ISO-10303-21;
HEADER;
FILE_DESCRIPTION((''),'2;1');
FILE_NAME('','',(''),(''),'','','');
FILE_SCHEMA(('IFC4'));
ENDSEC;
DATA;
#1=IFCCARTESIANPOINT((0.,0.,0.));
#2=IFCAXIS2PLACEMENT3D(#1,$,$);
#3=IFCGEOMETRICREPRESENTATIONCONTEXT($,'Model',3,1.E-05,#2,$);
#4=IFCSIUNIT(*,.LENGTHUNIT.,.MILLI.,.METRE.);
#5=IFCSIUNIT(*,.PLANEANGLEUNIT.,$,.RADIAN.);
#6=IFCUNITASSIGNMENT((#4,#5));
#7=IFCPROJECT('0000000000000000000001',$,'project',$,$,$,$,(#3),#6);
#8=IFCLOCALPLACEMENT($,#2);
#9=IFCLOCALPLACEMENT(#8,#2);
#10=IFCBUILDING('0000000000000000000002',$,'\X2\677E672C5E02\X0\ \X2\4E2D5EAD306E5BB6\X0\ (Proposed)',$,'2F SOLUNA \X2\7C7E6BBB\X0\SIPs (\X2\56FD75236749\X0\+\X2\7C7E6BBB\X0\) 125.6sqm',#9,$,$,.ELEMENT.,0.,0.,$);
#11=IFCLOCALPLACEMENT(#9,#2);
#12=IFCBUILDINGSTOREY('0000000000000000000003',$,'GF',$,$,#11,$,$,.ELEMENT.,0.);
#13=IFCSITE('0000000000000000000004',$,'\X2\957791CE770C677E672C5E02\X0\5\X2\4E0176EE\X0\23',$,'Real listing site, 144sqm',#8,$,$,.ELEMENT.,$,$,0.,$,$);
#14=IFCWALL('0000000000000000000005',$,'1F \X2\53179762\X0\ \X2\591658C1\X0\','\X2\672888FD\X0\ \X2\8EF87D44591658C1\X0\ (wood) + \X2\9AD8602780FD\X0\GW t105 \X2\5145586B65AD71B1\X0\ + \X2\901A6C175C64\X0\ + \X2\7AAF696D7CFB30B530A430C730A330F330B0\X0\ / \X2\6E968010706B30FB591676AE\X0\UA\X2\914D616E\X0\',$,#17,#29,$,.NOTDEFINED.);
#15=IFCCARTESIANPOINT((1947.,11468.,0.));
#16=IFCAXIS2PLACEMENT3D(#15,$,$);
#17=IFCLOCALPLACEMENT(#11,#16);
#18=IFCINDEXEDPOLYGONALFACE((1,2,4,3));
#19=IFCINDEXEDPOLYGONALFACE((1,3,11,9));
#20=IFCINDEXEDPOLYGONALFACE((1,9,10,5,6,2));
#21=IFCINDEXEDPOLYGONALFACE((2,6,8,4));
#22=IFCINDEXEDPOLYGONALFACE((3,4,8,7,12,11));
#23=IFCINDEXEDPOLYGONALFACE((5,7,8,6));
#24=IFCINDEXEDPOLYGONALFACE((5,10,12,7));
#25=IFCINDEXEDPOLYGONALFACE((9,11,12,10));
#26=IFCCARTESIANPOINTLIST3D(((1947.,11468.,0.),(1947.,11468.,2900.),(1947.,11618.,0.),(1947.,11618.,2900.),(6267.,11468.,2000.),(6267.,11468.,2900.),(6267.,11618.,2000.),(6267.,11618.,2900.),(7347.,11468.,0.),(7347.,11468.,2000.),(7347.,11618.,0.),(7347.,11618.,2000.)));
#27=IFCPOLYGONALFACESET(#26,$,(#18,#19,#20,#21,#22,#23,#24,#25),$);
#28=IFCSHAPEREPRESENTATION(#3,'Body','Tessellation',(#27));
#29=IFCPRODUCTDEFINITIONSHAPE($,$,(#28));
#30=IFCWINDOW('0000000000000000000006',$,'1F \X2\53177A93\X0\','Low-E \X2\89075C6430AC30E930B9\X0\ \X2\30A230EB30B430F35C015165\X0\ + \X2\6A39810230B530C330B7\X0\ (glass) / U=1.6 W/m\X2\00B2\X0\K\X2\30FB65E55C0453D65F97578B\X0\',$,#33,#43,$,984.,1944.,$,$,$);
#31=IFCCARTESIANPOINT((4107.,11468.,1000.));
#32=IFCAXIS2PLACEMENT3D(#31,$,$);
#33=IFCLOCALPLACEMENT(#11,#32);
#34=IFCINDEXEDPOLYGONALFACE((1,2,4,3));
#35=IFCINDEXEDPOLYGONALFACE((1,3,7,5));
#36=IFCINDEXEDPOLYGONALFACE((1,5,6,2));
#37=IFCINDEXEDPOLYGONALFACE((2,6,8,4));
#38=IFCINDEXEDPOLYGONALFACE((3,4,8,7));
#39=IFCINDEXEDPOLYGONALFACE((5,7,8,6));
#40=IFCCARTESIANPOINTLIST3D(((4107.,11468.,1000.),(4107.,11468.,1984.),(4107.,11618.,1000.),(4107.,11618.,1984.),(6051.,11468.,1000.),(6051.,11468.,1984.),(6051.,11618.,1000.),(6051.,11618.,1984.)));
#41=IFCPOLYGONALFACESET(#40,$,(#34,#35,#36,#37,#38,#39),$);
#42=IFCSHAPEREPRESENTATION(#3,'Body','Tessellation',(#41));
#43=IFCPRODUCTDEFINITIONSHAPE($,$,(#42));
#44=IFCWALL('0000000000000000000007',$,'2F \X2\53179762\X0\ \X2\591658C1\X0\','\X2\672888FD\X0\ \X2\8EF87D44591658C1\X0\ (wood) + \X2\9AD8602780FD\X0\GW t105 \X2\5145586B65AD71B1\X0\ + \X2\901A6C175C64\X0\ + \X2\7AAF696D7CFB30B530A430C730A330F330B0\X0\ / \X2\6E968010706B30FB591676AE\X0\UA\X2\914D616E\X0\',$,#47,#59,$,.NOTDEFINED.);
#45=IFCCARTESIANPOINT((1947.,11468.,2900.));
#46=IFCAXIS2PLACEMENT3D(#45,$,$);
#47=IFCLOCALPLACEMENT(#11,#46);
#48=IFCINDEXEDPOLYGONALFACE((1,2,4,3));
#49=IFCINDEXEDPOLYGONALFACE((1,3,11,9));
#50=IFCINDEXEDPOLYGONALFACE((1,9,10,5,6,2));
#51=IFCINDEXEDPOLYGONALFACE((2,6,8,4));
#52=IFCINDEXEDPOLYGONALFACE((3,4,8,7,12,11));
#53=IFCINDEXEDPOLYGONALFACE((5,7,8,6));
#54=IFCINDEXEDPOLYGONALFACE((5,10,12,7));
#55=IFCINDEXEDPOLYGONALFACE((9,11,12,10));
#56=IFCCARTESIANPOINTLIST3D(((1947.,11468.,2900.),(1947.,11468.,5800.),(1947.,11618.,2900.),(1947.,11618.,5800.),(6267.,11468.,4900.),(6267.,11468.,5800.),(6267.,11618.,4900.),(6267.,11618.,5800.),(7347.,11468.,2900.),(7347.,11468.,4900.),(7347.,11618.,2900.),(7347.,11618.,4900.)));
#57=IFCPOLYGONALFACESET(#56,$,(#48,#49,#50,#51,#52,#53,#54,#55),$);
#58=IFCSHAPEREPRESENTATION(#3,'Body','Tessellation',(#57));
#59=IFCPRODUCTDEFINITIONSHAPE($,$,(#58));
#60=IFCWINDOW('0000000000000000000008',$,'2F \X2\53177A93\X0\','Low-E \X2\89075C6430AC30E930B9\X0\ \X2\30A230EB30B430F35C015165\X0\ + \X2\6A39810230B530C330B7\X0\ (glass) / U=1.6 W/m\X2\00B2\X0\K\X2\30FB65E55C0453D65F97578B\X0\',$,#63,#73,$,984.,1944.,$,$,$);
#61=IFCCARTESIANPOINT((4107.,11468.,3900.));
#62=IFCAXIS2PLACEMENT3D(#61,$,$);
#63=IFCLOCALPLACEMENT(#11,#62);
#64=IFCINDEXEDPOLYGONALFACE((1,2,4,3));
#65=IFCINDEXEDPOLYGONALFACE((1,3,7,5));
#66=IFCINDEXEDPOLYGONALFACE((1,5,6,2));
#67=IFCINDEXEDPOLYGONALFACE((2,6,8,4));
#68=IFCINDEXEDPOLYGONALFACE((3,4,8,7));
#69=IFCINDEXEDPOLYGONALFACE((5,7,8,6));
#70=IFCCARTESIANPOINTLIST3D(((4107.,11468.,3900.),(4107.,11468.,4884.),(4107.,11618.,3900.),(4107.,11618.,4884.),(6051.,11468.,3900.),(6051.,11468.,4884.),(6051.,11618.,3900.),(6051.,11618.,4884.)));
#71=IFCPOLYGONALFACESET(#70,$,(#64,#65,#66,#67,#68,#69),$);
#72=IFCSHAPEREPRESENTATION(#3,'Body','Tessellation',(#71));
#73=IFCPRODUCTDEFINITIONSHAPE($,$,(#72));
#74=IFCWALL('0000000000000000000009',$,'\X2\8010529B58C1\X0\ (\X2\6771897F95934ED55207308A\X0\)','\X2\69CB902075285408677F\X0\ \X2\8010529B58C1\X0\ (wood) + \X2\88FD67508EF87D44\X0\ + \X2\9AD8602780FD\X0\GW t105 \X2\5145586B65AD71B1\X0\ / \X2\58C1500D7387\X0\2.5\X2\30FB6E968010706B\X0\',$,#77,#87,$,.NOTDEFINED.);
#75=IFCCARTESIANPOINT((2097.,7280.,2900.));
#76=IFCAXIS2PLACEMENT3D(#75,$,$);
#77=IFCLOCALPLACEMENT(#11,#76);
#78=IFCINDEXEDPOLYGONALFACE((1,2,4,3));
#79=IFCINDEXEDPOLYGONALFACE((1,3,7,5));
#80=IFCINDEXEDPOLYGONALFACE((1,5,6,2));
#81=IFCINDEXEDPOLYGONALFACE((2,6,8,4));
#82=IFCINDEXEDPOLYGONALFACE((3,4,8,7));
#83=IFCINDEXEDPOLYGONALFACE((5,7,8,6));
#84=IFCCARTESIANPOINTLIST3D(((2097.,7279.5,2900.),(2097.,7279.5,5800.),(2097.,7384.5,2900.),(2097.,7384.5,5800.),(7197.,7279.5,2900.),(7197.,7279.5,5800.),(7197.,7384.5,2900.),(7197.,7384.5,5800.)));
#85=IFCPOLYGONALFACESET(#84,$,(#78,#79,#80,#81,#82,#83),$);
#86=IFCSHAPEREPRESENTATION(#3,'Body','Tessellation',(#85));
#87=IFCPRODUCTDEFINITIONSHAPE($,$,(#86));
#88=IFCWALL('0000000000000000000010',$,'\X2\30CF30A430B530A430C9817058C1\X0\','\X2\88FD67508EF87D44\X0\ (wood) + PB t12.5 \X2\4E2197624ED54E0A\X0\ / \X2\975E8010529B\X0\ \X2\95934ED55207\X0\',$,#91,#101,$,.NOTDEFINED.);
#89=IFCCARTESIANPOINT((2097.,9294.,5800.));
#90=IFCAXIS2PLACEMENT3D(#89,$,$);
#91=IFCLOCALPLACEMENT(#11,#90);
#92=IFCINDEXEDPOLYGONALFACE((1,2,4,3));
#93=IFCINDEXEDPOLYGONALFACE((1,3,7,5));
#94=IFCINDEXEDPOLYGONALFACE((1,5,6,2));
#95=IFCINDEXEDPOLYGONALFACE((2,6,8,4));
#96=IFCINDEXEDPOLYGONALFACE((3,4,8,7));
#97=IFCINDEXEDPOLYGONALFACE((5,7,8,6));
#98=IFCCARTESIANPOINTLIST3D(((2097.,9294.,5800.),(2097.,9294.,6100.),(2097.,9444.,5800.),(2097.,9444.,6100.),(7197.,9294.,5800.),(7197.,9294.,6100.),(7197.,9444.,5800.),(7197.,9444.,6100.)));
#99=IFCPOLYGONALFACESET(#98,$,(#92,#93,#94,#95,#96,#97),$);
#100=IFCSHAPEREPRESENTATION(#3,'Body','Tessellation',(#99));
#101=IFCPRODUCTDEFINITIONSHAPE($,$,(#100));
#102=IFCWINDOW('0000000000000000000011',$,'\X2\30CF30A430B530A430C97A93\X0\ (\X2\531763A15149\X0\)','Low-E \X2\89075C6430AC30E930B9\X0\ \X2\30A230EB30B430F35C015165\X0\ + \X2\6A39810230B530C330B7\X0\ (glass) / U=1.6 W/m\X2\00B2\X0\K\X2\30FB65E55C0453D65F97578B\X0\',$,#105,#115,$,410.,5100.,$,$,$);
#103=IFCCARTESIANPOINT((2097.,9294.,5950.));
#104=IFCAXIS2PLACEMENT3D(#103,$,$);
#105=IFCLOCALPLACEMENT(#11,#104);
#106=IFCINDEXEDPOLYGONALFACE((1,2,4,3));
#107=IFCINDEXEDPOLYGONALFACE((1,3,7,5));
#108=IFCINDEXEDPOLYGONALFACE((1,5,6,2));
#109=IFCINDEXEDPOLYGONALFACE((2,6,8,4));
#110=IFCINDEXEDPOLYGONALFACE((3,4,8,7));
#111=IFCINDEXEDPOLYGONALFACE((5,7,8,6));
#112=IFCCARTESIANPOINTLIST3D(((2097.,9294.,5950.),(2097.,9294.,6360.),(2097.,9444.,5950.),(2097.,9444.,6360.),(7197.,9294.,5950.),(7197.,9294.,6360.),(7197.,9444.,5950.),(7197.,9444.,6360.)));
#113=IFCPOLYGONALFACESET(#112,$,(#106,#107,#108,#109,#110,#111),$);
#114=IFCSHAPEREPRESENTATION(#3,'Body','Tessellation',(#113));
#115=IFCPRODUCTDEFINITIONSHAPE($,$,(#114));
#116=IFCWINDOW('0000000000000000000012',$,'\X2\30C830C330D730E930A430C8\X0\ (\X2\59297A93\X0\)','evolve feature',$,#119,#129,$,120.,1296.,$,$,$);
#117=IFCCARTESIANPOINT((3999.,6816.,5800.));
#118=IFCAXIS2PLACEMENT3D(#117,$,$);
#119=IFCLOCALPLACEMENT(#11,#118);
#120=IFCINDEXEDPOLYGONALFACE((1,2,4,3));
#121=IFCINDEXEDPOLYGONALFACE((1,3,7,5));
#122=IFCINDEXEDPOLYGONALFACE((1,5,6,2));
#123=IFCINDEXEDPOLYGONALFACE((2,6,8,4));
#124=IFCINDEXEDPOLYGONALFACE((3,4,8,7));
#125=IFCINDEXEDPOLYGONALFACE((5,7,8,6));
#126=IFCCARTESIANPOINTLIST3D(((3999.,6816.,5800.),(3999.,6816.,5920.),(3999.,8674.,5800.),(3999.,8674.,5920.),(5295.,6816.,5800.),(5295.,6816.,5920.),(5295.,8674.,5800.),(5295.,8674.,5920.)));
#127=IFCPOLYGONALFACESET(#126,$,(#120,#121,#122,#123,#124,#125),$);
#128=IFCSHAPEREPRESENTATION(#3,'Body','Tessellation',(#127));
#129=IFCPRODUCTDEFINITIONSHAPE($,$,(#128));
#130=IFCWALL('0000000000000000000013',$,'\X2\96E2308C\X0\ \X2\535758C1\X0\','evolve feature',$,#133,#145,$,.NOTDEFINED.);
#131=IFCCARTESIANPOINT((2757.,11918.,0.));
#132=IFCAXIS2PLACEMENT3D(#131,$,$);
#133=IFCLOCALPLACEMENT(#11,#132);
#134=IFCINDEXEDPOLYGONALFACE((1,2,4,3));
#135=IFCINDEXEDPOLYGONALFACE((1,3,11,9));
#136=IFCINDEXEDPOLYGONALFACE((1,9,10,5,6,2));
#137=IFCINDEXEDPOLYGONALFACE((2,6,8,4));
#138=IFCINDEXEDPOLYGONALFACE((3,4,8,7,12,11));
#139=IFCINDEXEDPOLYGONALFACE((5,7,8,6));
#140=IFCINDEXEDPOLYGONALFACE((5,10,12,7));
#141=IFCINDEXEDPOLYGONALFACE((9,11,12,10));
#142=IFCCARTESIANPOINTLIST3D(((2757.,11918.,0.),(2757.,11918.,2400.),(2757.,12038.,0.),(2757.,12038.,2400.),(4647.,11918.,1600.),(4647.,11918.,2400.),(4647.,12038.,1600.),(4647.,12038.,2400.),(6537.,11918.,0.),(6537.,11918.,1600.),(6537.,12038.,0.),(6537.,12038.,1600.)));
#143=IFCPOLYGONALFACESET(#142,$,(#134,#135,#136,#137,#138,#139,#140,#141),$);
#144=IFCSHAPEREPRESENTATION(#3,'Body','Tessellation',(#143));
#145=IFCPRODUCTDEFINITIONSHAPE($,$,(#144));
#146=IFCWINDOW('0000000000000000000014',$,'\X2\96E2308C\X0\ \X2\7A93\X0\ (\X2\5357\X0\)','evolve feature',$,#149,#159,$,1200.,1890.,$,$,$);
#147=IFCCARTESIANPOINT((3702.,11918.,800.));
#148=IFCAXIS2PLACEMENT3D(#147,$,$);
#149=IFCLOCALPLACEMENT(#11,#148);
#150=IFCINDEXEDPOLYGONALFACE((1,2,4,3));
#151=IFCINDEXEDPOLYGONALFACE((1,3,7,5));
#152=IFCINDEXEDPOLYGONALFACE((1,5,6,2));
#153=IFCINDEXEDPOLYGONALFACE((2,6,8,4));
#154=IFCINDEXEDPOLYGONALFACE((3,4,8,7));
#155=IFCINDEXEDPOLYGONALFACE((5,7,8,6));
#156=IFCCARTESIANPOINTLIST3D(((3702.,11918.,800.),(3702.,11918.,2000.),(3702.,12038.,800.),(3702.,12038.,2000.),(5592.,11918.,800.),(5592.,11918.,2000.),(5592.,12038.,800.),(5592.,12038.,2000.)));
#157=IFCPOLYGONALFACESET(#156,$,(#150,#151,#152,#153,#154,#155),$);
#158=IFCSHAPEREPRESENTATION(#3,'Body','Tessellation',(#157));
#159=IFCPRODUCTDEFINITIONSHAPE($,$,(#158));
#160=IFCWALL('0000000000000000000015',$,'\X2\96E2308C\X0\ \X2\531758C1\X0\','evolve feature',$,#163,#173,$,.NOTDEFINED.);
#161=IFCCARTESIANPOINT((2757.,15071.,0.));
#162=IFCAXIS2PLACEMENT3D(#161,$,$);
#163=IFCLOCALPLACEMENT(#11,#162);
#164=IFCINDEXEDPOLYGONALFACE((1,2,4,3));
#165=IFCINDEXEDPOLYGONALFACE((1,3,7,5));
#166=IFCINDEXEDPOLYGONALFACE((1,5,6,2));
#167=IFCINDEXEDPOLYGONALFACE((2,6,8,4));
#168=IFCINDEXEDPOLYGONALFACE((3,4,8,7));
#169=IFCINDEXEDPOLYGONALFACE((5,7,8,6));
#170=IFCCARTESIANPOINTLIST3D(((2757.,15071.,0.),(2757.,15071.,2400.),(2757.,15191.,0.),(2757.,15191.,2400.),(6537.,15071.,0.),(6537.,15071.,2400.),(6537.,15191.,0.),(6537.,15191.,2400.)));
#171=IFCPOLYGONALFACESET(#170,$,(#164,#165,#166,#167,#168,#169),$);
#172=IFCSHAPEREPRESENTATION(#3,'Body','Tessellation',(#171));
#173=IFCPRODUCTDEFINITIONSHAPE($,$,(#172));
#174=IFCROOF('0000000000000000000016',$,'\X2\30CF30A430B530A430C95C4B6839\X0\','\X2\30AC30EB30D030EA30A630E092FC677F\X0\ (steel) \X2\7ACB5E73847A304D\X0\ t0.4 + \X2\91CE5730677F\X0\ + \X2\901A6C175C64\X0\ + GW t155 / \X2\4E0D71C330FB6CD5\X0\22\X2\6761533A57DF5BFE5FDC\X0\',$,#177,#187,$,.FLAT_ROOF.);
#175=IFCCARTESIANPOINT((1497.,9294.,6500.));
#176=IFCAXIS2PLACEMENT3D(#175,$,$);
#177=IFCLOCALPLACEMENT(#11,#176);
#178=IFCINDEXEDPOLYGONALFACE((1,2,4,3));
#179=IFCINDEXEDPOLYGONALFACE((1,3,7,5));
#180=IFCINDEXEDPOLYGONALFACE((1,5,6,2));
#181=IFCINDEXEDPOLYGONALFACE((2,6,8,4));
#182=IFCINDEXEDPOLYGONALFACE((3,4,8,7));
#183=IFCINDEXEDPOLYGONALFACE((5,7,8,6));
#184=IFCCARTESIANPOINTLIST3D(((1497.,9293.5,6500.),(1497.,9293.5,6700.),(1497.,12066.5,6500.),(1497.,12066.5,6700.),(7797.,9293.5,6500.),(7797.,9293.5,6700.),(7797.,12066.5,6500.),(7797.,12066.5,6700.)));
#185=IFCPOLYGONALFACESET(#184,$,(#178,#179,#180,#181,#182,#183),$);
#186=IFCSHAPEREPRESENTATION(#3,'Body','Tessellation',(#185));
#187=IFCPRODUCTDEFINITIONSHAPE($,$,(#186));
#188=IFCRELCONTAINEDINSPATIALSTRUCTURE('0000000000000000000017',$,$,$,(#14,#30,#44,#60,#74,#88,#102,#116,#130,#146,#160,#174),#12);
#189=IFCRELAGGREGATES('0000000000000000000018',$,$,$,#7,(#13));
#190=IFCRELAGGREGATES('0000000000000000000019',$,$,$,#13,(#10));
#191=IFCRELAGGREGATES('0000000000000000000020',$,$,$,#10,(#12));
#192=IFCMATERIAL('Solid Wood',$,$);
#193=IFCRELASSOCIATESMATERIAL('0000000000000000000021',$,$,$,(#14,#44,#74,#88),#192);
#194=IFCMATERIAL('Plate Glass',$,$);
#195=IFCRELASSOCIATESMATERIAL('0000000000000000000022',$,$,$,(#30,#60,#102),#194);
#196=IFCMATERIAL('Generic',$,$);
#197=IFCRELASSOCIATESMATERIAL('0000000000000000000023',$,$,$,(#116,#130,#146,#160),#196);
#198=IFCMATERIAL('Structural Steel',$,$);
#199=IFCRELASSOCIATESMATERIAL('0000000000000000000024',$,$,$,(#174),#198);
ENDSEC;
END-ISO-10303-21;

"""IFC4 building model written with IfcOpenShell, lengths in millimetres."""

from ifc_helpers import new_model, si_unit, frame, frame_2d, origin, place, context, project, spatial, rectangle, extrude, material, element, fill, save


model = new_model("IFC4")

# Units and contexts
model_context = context("Model", 3, precision=1e-05, world=origin())
ifc_project = project(units=[si_unit("LENGTHUNIT", "METRE", prefix="MILLI"), si_unit("PLANEANGLEUNIT", "RADIAN")], contexts=[model_context])

# Site, building, storey
site_placement = place(None, origin())
site = spatial("IfcSite", under=ifc_project, at=site_placement, Name="長野県松本市5丁目23", ObjectType="Real listing site, 144sqm", CompositionType="ELEMENT", RefElevation=0.0)
building_placement = place(site_placement, origin())
building = spatial("IfcBuilding", under=site, at=building_placement, Name="松本市 中庭の家 (Proposed)", ObjectType="2F SOLUNA 籾殻SIPs (国産杉+籾殻) 125.6sqm", CompositionType="ELEMENT", ElevationOfRefHeight=0.0, ElevationOfTerrain=0.0)
storey_placement = place(building_placement, origin())
storey = spatial("IfcBuildingStorey", under=building, at=storey_placement, Name="GF", CompositionType="ELEMENT", Elevation=0.0)

# Shared definitions
ifc_material_1 = material(Name="Generic")

# Wall, opening, window
ifc_material_2 = material(Name="Solid Wood")
wall_1_placement = place(storey_placement, frame((1947.0, 11468.0, 0.0)))
wall_1 = element("IfcWall", 1, at=wall_1_placement, inside=storey, material=ifc_material_2, Name="1F 北面 外壁", Description="木製 軸組外壁 (wood) + 高性能GW t105 充填断熱 + 通気層 + 窯業系サイディング / 準耐火・外皮UA配慮", PredefinedType="NOTDEFINED", context=model_context, shape_type="SweptSolid", body=[
    extrude(rectangle(XDim=5400.0, YDim=150.0, at=frame_2d((2700.0, 75.0))), frame((1947.0, 11468.0, 0.0)), (0.0, 0.0, 1.0), 2900.0),
])
opening_1_placement = place(storey_placement, frame((4107.0, 11468.0, 1000.0)))
opening_1 = element("IfcOpeningElement", 2, at=opening_1_placement, cuts=wall_1, PredefinedType="NOTDEFINED", context=model_context, shape_type="SweptSolid", body=[
    extrude(rectangle(XDim=1944.0, YDim=150.0, at=frame_2d((972.0, 75.0))), frame((4107.0, 11468.0, 1000.0)), (0.0, 0.0, 1.0), 984.0),
])
ifc_material_3 = material(Name="Plate Glass")
window_1_placement = place(storey_placement, frame((4107.0, 11468.0, 1000.0)))
window_1 = element("IfcWindow", 3, at=window_1_placement, inside=storey, material=ifc_material_3, Name="1F 北窓", Description="Low-E 複層ガラス アルゴン封入 + 樹脂サッシ (glass) / U=1.6 W/m²K・日射取得型", OverallHeight=984.0, OverallWidth=1944.0, context=model_context, shape_type="SweptSolid", body=[
    extrude(rectangle(XDim=1944.0, YDim=150.0, at=frame_2d((972.0, 75.0))), frame((4107.0, 11468.0, 1000.0)), (0.0, 0.0, 1.0), 984.0),
])
fill(opening_1, window_1)

# Wall, opening, window
wall_2_placement = place(storey_placement, frame((1947.0, 11468.0, 2900.0)))
wall_2 = element("IfcWall", 4, at=wall_2_placement, inside=storey, material=ifc_material_2, Name="2F 北面 外壁", Description="木製 軸組外壁 (wood) + 高性能GW t105 充填断熱 + 通気層 + 窯業系サイディング / 準耐火・外皮UA配慮", PredefinedType="NOTDEFINED", context=model_context, shape_type="SweptSolid", body=[
    extrude(rectangle(XDim=5400.0, YDim=150.0, at=frame_2d((2700.0, 75.0))), frame((1947.0, 11468.0, 2900.0)), (0.0, 0.0, 1.0), 2900.0),
])
opening_2_placement = place(storey_placement, frame((4107.0, 11468.0, 3900.0)))
opening_2 = element("IfcOpeningElement", 5, at=opening_2_placement, cuts=wall_2, PredefinedType="NOTDEFINED", context=model_context, shape_type="SweptSolid", body=[
    extrude(rectangle(XDim=1944.0, YDim=150.0, at=frame_2d((972.0, 75.0))), frame((4107.0, 11468.0, 3900.0)), (0.0, 0.0, 1.0), 984.0),
])
window_2_placement = place(storey_placement, frame((4107.0, 11468.0, 3900.0)))
window_2 = element("IfcWindow", 6, at=window_2_placement, inside=storey, material=ifc_material_3, Name="2F 北窓", Description="Low-E 複層ガラス アルゴン封入 + 樹脂サッシ (glass) / U=1.6 W/m²K・日射取得型", OverallHeight=984.0, OverallWidth=1944.0, context=model_context, shape_type="SweptSolid", body=[
    extrude(rectangle(XDim=1944.0, YDim=150.0, at=frame_2d((972.0, 75.0))), frame((4107.0, 11468.0, 3900.0)), (0.0, 0.0, 1.0), 984.0),
])
fill(opening_2, window_2)

# Wall
wall_3_placement = place(storey_placement, frame((2097.0, 7280.0, 2900.0)))
element("IfcWall", 7, at=wall_3_placement, inside=storey, material=ifc_material_2, Name="耐力壁 (東西間仕切り)", Description="構造用合板 耐力壁 (wood) + 製材軸組 + 高性能GW t105 充填断熱 / 壁倍率2.5・準耐火", PredefinedType="NOTDEFINED", context=model_context, shape_type="SweptSolid", body=[
    extrude(rectangle(XDim=5100.0, YDim=105.0, at=frame_2d((2550.0, 52.0))), frame((2097.0, 7280.0, 2900.0)), (0.0, 0.0, 1.0), 2900.0),
])

# Wall, opening, window
wall_4_placement = place(storey_placement, frame((2097.0, 9294.0, 5800.0)))
wall_4 = element("IfcWall", 8, at=wall_4_placement, inside=storey, material=ifc_material_2, Name="ハイサイド腰壁", Description="製材軸組 (wood) + PB t12.5 両面仕上 / 非耐力 間仕切", PredefinedType="NOTDEFINED", context=model_context, shape_type="SweptSolid", body=[
    extrude(rectangle(XDim=5100.0, YDim=150.0, at=frame_2d((2550.0, 75.0))), frame((2097.0, 9294.0, 5800.0)), (0.0, 0.0, 1.0), 700.0),
])
opening_3_placement = place(storey_placement, frame((2097.0, 9294.0, 5950.0)))
opening_3 = element("IfcOpeningElement", 9, at=opening_3_placement, cuts=wall_4, PredefinedType="NOTDEFINED", context=model_context, shape_type="SweptSolid", body=[
    extrude(rectangle(XDim=5100.0, YDim=150.0, at=frame_2d((2550.0, 75.0))), frame((2097.0, 9294.0, 5950.0)), (0.0, 0.0, 1.0), 410.0),
])
window_3_placement = place(storey_placement, frame((2097.0, 9294.0, 5950.0)))
window_3 = element("IfcWindow", 10, at=window_3_placement, inside=storey, material=ifc_material_3, Name="ハイサイド窓 (北採光)", Description="Low-E 複層ガラス アルゴン封入 + 樹脂サッシ (glass) / U=1.6 W/m²K・日射取得型", OverallHeight=410.0, OverallWidth=5100.0, context=model_context, shape_type="SweptSolid", body=[
    extrude(rectangle(XDim=5100.0, YDim=150.0, at=frame_2d((2550.0, 75.0))), frame((2097.0, 9294.0, 5950.0)), (0.0, 0.0, 1.0), 410.0),
])
fill(opening_3, window_3)

# Window
window_4_placement = place(storey_placement, frame((3999.0, 6816.0, 5800.0)))
element("IfcWindow", 11, at=window_4_placement, inside=storey, material=ifc_material_1, Name="トップライト (天窓)", Description="evolve feature", OverallHeight=120.0, OverallWidth=1296.0, context=model_context, shape_type="SweptSolid", body=[
    extrude(rectangle(XDim=1296.0, YDim=1858.0, at=frame_2d((648.0, 929.0))), frame((3999.0, 6816.0, 5800.0)), (0.0, 0.0, 1.0), 120.0),
])

# Wall, opening, window
wall_5_placement = place(storey_placement, frame((2757.0, 11918.0, 0.0)))
wall_5 = element("IfcWall", 12, at=wall_5_placement, inside=storey, material=ifc_material_1, Name="離れ 南壁", Description="evolve feature", PredefinedType="NOTDEFINED", context=model_context, shape_type="SweptSolid", body=[
    extrude(rectangle(XDim=3780.0, YDim=120.0, at=frame_2d((1890.0, 60.0))), frame((2757.0, 11918.0, 0.0)), (0.0, 0.0, 1.0), 2400.0),
])
opening_4_placement = place(storey_placement, frame((3702.0, 11918.0, 800.0)))
opening_4 = element("IfcOpeningElement", 13, at=opening_4_placement, cuts=wall_5, PredefinedType="NOTDEFINED", context=model_context, shape_type="SweptSolid", body=[
    extrude(rectangle(XDim=1890.0, YDim=120.0, at=frame_2d((945.0, 60.0))), frame((3702.0, 11918.0, 800.0)), (0.0, 0.0, 1.0), 1200.0),
])
window_5_placement = place(storey_placement, frame((3702.0, 11918.0, 800.0)))
window_5 = element("IfcWindow", 14, at=window_5_placement, inside=storey, material=ifc_material_1, Name="離れ 窓 (南)", Description="evolve feature", OverallHeight=1200.0, OverallWidth=1890.0, context=model_context, shape_type="SweptSolid", body=[
    extrude(rectangle(XDim=1890.0, YDim=120.0, at=frame_2d((945.0, 60.0))), frame((3702.0, 11918.0, 800.0)), (0.0, 0.0, 1.0), 1200.0),
])
fill(opening_4, window_5)

# Wall
wall_6_placement = place(storey_placement, frame((2757.0, 15071.0, 0.0)))
element("IfcWall", 15, at=wall_6_placement, inside=storey, material=ifc_material_1, Name="離れ 北壁", Description="evolve feature", PredefinedType="NOTDEFINED", context=model_context, shape_type="SweptSolid", body=[
    extrude(rectangle(XDim=3780.0, YDim=120.0, at=frame_2d((1890.0, 60.0))), frame((2757.0, 15071.0, 0.0)), (0.0, 0.0, 1.0), 2400.0),
])

# Roof
ifc_material_4 = material(Name="Structural Steel")
roof_1_placement = place(storey_placement, frame((1497.0, 9294.0, 6500.0)))
element("IfcRoof", 16, at=roof_1_placement, inside=storey, material=ifc_material_4, Name="ハイサイド屋根", Description="ガルバリウム鋼板 (steel) 立平葺き t0.4 + 野地板 + 通気層 + GW t155 / 不燃・法22条区域対応", PredefinedType="FLAT_ROOF", context=model_context, shape_type="SweptSolid", body=[
    extrude(rectangle(XDim=6300.0, YDim=2773.0, at=frame_2d((3150.0, 1386.0))), frame((1497.0, 9294.0, 6500.0)), (0.0, 0.0, 1.0), 200.0),
])

save(model, "model.ifc")
